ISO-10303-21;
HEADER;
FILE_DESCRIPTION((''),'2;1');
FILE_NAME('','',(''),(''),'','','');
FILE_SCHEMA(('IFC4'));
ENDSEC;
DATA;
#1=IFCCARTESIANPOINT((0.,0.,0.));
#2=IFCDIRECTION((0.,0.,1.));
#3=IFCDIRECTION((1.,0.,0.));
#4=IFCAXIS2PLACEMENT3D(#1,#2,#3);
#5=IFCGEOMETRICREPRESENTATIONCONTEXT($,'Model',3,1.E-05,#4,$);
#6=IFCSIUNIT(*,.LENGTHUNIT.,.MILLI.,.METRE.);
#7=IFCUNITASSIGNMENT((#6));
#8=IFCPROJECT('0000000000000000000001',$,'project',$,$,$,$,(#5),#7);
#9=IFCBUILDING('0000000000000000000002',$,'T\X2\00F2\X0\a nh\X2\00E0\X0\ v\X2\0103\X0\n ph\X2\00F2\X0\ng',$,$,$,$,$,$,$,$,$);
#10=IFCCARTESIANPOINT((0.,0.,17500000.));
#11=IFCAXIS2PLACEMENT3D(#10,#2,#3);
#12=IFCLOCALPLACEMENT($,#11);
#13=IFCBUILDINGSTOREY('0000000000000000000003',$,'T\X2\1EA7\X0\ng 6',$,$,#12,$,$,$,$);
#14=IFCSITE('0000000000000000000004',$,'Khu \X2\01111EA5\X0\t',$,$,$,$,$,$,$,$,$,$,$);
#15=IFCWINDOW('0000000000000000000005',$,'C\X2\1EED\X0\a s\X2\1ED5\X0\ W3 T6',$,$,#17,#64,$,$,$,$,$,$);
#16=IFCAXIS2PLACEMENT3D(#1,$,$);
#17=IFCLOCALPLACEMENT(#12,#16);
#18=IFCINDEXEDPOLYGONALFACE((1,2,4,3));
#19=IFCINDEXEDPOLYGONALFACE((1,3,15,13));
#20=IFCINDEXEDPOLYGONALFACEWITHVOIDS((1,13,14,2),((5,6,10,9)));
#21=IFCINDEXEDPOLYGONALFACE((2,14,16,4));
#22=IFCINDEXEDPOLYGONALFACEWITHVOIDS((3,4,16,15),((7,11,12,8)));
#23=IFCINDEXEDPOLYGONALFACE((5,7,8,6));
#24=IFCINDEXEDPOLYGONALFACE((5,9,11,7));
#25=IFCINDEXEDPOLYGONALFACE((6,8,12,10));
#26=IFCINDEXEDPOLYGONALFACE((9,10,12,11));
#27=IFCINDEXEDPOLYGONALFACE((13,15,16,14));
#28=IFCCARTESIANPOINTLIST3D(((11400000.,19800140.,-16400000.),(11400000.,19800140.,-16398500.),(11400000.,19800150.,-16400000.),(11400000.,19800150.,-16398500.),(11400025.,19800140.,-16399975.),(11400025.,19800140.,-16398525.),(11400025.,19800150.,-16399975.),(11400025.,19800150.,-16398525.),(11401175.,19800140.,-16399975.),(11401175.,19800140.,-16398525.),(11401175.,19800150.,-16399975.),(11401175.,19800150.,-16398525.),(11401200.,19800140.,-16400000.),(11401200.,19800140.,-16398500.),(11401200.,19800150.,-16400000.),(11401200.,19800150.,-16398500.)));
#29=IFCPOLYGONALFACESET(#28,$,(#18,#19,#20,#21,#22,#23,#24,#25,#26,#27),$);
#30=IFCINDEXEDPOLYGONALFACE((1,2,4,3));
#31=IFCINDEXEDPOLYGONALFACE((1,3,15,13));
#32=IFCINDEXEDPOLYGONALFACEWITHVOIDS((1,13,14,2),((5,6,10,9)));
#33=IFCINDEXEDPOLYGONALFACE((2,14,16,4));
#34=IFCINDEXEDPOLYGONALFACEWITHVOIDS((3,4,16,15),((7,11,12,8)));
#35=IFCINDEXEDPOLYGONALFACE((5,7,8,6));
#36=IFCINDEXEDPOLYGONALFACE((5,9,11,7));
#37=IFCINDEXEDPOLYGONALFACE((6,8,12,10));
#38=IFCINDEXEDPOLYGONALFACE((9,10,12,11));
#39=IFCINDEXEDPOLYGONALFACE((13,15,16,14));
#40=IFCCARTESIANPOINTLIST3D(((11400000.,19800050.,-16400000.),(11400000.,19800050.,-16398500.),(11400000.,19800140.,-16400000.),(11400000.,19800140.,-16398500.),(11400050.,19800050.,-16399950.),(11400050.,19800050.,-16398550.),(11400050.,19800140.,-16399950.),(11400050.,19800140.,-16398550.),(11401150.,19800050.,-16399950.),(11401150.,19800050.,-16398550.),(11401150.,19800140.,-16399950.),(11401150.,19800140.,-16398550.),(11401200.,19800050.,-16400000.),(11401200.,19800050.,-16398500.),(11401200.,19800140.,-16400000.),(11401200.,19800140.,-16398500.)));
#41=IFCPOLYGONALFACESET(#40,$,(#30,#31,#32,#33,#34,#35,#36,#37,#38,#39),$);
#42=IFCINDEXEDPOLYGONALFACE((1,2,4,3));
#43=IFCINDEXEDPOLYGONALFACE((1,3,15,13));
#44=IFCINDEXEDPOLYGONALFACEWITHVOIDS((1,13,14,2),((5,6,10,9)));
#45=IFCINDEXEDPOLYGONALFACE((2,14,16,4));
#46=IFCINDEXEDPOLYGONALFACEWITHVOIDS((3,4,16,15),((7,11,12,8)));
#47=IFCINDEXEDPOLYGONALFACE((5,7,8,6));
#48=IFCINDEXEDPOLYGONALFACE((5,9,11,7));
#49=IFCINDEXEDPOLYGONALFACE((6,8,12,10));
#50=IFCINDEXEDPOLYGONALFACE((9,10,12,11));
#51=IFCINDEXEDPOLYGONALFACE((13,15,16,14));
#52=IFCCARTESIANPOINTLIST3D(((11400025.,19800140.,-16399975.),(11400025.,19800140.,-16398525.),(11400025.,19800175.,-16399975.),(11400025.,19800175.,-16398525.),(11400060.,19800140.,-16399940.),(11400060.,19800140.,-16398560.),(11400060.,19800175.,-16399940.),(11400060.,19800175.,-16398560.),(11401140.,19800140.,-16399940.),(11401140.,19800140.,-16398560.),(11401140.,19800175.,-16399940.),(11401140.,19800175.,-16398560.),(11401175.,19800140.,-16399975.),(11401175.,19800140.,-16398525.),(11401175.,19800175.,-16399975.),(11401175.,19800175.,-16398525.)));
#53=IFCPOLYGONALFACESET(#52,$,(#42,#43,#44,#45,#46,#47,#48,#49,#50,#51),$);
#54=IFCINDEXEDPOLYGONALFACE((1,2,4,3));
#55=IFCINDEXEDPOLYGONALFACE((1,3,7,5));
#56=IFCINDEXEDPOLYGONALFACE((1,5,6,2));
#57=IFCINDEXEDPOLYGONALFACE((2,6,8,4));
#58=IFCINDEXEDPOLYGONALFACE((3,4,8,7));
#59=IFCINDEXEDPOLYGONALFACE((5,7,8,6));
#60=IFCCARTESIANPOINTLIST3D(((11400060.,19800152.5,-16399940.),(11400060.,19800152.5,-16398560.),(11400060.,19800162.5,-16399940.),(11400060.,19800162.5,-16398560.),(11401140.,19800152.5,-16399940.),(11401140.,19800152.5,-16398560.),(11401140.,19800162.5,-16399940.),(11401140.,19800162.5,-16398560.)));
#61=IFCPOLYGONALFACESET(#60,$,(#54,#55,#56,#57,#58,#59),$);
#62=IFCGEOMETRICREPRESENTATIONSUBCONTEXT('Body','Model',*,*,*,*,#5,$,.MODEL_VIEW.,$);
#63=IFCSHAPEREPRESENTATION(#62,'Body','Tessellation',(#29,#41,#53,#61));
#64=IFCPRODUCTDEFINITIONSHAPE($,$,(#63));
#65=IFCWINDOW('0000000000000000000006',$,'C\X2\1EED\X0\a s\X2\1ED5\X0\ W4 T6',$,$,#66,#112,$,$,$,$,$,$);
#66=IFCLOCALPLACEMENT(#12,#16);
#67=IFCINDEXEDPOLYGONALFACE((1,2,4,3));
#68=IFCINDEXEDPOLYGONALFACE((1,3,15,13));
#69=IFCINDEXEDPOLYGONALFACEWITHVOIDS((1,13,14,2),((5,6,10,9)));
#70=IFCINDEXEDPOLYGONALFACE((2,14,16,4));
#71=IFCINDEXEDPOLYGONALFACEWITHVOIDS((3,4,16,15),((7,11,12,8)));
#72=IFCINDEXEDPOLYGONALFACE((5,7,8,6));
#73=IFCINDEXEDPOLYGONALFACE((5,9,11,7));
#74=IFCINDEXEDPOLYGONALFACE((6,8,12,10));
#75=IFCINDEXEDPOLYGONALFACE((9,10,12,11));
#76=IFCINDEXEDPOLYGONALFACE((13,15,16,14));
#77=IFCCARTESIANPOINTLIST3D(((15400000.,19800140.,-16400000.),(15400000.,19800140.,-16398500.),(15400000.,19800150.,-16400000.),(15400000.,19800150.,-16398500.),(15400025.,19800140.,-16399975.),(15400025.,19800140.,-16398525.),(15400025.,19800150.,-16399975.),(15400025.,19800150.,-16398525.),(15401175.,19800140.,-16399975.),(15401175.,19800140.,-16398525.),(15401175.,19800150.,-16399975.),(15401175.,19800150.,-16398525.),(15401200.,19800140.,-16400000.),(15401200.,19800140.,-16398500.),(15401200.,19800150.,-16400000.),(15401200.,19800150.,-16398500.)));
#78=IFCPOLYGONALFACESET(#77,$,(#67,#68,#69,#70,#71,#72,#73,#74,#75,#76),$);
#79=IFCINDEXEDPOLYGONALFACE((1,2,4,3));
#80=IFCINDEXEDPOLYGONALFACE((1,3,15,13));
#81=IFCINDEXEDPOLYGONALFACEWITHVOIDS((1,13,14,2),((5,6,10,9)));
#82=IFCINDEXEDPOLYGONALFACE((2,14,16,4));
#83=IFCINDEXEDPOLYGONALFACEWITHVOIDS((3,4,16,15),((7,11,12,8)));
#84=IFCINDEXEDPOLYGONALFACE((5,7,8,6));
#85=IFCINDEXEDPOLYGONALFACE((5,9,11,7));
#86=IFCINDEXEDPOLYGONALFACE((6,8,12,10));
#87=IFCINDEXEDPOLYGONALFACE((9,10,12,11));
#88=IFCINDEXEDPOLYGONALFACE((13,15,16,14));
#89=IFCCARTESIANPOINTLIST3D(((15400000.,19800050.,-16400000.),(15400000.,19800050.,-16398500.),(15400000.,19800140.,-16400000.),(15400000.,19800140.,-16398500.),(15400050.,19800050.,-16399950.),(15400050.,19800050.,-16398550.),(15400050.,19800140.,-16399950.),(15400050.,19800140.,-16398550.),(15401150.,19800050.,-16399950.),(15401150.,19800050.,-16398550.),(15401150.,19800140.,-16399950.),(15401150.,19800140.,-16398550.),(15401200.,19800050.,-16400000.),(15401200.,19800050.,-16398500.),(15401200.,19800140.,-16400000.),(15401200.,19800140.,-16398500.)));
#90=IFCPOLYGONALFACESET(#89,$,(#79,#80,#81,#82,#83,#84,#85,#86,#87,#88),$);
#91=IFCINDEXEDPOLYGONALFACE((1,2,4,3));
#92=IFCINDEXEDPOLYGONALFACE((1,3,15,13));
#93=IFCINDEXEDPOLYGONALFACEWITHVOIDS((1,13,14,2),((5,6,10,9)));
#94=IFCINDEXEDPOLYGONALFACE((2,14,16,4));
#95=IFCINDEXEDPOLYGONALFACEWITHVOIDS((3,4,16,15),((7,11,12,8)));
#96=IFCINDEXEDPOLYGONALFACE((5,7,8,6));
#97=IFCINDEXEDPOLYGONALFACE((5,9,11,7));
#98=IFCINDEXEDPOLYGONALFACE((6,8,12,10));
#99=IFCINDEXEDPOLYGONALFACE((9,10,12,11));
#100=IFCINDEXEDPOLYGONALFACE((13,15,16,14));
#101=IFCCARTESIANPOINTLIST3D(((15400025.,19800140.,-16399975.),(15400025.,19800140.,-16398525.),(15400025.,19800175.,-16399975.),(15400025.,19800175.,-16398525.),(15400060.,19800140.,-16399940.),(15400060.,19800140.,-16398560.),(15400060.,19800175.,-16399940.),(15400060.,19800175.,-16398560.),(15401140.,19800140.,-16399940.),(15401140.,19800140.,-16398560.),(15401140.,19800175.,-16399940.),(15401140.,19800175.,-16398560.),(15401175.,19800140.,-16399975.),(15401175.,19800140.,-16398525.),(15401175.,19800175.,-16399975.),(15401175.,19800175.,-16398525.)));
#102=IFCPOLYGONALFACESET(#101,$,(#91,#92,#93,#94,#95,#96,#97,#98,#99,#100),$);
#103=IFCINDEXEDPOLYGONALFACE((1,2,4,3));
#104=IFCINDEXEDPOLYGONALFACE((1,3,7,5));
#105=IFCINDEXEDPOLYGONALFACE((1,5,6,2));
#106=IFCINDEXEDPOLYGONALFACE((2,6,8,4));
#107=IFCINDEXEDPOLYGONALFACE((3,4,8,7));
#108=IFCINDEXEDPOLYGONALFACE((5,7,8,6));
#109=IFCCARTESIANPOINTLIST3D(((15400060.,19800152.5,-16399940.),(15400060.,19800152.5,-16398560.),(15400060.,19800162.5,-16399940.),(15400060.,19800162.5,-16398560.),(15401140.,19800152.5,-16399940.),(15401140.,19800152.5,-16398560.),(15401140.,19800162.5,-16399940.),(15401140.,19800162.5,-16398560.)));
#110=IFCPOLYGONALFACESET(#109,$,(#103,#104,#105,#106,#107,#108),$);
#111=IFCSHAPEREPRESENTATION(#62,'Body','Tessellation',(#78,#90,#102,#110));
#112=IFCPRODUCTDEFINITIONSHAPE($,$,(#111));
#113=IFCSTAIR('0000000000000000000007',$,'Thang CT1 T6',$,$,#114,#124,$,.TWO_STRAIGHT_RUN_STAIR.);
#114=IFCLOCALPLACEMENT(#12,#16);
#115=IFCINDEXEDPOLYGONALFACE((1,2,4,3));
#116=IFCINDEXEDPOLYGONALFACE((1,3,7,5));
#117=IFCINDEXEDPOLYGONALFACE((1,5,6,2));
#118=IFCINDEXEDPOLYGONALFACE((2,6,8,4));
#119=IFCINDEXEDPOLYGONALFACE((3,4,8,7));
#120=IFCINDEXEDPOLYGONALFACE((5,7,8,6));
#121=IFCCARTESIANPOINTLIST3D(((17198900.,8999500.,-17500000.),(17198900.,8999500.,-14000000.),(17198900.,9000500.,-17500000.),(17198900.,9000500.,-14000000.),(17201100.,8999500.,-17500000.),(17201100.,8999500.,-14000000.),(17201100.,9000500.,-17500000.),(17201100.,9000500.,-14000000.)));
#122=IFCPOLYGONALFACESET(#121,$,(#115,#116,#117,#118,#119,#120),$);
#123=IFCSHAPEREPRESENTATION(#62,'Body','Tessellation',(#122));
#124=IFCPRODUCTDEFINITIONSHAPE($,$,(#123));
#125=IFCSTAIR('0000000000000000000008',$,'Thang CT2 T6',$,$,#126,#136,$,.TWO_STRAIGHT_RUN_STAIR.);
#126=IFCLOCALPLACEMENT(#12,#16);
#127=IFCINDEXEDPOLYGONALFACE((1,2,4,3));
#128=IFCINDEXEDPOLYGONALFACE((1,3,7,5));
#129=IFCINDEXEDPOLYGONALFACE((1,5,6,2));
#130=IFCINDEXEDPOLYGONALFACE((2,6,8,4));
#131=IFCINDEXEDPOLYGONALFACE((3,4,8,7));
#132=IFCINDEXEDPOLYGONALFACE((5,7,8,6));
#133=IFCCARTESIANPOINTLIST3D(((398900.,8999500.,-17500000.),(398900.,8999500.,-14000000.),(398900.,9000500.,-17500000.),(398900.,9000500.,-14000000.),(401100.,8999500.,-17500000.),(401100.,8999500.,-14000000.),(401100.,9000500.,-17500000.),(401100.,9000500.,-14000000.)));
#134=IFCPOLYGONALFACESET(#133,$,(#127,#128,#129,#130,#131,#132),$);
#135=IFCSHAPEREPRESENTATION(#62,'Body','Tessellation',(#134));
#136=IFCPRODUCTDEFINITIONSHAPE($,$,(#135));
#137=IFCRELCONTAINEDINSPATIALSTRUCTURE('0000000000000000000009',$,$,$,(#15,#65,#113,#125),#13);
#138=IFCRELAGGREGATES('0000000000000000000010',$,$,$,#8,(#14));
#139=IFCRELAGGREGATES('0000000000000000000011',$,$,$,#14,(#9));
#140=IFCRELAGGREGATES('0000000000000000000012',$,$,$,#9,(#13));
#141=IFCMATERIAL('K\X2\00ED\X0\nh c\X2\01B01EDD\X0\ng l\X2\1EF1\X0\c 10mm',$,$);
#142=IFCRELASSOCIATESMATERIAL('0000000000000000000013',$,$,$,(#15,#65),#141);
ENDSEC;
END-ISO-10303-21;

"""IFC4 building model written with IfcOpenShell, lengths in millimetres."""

from ifc_helpers import new_model, entity, si_unit, frame, origin_with_axes, place, context, subcontext, project, spatial, line, indexed_curve, outline, extrude, material, element, save


model = new_model("IFC4")

# Units and contexts
model_context = context("Model", 3, precision=1e-05, world=origin_with_axes())
body_context = subcontext(model_context, "Body", "Model", "MODEL_VIEW")
ifc_project = project(units=[si_unit("LENGTHUNIT", "METRE", prefix="MILLI")], contexts=[model_context])

# Site, building, storey
site = spatial("IfcSite", under=ifc_project, Name="Khu đất")
building = spatial("IfcBuilding", under=site, Name="Tòa nhà văn phòng")
storey_placement = place(None, frame((0.0, 0.0, 17500000.0), z_axis=(0.0, 0.0, 1.0), x_axis=(1.0, 0.0, 0.0)))
storey = spatial("IfcBuildingStorey", under=building, at=storey_placement, Name="Tầng 6")

# Windows
ifc_material_1 = material(Name="Kính cường lực 10mm")
for number, where, z_axis, x_axis, name in (
    (1, (11400000.0, 19800000.0, -16400000.0), (0.0, 0.0, 1.0), (1.0, 0.0, 0.0), "Cửa sổ W3 T6"),
    (2, (15400000.0, 19800000.0, -16400000.0), (0.0, 0.0, 1.0), (1.0, 0.0, 0.0), "Cửa sổ W4 T6"),
):
    element("IfcWindow", number, at=place(storey_placement, frame(where, z_axis=z_axis, x_axis=x_axis)), inside=storey, material=ifc_material_1, Name=name, context=body_context, shape_type="SolidModel", body=[
        extrude(outline(indexed_curve([(0.0, 0.0), (1200.0, 0.0), (1200.0, 1500.0), (0.0, 1500.0)], segments=[line(1, 2, 3, 4, 1)]), holes=[indexed_curve([(25.0, 25.0), (1175.0, 25.0), (1175.0, 1475.0), (25.0, 1475.0)], segments=[line(1, 2, 3, 4, 1)])]), frame((0.0, 140.0, 0.0), z_axis=(0.0, -1.0, 0.0), x_axis=(1.0, 0.0, 0.0)), (0.0, 0.0, -1.0), 10.0),
        extrude(outline(indexed_curve([(0.0, 0.0), (1200.0, 0.0), (1200.0, 1500.0), (0.0, 1500.0)], segments=[line(1, 2, 3, 4, 1)]), holes=[indexed_curve([(50.0, 50.0), (1150.0, 50.0), (1150.0, 1450.0), (50.0, 1450.0)], segments=[line(1, 2, 3, 4, 1)])]), frame((0.0, 50.0, 0.0), z_axis=(0.0, -1.0, 0.0), x_axis=(1.0, 0.0, 0.0)), (0.0, 0.0, -1.0), 90.0),
        extrude(outline(indexed_curve([(0.0, 0.0), (1150.0, 0.0), (1150.0, 1450.0), (0.0, 1450.0)], segments=[line(1, 2, 3, 4, 1)]), holes=[indexed_curve([(35.0, 35.0), (1115.0, 35.0), (1115.0, 1415.0), (35.0, 1415.0)], segments=[line(1, 2, 3, 4, 1)])]), frame((25.0, 140.0, 25.0), z_axis=(0.0, -1.0, 0.0), x_axis=(1.0, 0.0, 0.0)), (0.0, 0.0, -1.0), 35.0),
        extrude(outline(indexed_curve([(35.0, 35.0), (1115.0, 35.0), (1115.0, 1415.0), (35.0, 1415.0)], segments=[line(1, 2, 3, 4, 1)])), frame((25.0, 152.5, 25.0), z_axis=(0.0, -1.0, 0.0), x_axis=(1.0, 0.0, 0.0)), (0.0, 0.0, -1.0), 10.0),
    ])

# Stairs
for number, where, z_axis, x_axis, name in (
    (3, (17200000.0, 9000000.0, -17500000.0), (0.0, 0.0, 1.0), (1.0, 0.0, 0.0), "Thang CT1 T6"),
    (4, (400000.0, 9000000.0, -17500000.0), (0.0, 0.0, 1.0), (1.0, 0.0, 0.0), "Thang CT2 T6"),
):
    element("IfcStair", number, at=place(storey_placement, frame(where, z_axis=z_axis, x_axis=x_axis)), inside=storey, Name=name, PredefinedType="TWO_STRAIGHT_RUN_STAIR", context=body_context, shape_type="SweptSolid", body=[
        extrude(entity("IfcRectangleProfileDef", None, None, None, 2200.0, 1000.0), origin_with_axes(), (0.0, 0.0, 1.0), 3500000.0),
    ])

save(model, "model.ifc")
